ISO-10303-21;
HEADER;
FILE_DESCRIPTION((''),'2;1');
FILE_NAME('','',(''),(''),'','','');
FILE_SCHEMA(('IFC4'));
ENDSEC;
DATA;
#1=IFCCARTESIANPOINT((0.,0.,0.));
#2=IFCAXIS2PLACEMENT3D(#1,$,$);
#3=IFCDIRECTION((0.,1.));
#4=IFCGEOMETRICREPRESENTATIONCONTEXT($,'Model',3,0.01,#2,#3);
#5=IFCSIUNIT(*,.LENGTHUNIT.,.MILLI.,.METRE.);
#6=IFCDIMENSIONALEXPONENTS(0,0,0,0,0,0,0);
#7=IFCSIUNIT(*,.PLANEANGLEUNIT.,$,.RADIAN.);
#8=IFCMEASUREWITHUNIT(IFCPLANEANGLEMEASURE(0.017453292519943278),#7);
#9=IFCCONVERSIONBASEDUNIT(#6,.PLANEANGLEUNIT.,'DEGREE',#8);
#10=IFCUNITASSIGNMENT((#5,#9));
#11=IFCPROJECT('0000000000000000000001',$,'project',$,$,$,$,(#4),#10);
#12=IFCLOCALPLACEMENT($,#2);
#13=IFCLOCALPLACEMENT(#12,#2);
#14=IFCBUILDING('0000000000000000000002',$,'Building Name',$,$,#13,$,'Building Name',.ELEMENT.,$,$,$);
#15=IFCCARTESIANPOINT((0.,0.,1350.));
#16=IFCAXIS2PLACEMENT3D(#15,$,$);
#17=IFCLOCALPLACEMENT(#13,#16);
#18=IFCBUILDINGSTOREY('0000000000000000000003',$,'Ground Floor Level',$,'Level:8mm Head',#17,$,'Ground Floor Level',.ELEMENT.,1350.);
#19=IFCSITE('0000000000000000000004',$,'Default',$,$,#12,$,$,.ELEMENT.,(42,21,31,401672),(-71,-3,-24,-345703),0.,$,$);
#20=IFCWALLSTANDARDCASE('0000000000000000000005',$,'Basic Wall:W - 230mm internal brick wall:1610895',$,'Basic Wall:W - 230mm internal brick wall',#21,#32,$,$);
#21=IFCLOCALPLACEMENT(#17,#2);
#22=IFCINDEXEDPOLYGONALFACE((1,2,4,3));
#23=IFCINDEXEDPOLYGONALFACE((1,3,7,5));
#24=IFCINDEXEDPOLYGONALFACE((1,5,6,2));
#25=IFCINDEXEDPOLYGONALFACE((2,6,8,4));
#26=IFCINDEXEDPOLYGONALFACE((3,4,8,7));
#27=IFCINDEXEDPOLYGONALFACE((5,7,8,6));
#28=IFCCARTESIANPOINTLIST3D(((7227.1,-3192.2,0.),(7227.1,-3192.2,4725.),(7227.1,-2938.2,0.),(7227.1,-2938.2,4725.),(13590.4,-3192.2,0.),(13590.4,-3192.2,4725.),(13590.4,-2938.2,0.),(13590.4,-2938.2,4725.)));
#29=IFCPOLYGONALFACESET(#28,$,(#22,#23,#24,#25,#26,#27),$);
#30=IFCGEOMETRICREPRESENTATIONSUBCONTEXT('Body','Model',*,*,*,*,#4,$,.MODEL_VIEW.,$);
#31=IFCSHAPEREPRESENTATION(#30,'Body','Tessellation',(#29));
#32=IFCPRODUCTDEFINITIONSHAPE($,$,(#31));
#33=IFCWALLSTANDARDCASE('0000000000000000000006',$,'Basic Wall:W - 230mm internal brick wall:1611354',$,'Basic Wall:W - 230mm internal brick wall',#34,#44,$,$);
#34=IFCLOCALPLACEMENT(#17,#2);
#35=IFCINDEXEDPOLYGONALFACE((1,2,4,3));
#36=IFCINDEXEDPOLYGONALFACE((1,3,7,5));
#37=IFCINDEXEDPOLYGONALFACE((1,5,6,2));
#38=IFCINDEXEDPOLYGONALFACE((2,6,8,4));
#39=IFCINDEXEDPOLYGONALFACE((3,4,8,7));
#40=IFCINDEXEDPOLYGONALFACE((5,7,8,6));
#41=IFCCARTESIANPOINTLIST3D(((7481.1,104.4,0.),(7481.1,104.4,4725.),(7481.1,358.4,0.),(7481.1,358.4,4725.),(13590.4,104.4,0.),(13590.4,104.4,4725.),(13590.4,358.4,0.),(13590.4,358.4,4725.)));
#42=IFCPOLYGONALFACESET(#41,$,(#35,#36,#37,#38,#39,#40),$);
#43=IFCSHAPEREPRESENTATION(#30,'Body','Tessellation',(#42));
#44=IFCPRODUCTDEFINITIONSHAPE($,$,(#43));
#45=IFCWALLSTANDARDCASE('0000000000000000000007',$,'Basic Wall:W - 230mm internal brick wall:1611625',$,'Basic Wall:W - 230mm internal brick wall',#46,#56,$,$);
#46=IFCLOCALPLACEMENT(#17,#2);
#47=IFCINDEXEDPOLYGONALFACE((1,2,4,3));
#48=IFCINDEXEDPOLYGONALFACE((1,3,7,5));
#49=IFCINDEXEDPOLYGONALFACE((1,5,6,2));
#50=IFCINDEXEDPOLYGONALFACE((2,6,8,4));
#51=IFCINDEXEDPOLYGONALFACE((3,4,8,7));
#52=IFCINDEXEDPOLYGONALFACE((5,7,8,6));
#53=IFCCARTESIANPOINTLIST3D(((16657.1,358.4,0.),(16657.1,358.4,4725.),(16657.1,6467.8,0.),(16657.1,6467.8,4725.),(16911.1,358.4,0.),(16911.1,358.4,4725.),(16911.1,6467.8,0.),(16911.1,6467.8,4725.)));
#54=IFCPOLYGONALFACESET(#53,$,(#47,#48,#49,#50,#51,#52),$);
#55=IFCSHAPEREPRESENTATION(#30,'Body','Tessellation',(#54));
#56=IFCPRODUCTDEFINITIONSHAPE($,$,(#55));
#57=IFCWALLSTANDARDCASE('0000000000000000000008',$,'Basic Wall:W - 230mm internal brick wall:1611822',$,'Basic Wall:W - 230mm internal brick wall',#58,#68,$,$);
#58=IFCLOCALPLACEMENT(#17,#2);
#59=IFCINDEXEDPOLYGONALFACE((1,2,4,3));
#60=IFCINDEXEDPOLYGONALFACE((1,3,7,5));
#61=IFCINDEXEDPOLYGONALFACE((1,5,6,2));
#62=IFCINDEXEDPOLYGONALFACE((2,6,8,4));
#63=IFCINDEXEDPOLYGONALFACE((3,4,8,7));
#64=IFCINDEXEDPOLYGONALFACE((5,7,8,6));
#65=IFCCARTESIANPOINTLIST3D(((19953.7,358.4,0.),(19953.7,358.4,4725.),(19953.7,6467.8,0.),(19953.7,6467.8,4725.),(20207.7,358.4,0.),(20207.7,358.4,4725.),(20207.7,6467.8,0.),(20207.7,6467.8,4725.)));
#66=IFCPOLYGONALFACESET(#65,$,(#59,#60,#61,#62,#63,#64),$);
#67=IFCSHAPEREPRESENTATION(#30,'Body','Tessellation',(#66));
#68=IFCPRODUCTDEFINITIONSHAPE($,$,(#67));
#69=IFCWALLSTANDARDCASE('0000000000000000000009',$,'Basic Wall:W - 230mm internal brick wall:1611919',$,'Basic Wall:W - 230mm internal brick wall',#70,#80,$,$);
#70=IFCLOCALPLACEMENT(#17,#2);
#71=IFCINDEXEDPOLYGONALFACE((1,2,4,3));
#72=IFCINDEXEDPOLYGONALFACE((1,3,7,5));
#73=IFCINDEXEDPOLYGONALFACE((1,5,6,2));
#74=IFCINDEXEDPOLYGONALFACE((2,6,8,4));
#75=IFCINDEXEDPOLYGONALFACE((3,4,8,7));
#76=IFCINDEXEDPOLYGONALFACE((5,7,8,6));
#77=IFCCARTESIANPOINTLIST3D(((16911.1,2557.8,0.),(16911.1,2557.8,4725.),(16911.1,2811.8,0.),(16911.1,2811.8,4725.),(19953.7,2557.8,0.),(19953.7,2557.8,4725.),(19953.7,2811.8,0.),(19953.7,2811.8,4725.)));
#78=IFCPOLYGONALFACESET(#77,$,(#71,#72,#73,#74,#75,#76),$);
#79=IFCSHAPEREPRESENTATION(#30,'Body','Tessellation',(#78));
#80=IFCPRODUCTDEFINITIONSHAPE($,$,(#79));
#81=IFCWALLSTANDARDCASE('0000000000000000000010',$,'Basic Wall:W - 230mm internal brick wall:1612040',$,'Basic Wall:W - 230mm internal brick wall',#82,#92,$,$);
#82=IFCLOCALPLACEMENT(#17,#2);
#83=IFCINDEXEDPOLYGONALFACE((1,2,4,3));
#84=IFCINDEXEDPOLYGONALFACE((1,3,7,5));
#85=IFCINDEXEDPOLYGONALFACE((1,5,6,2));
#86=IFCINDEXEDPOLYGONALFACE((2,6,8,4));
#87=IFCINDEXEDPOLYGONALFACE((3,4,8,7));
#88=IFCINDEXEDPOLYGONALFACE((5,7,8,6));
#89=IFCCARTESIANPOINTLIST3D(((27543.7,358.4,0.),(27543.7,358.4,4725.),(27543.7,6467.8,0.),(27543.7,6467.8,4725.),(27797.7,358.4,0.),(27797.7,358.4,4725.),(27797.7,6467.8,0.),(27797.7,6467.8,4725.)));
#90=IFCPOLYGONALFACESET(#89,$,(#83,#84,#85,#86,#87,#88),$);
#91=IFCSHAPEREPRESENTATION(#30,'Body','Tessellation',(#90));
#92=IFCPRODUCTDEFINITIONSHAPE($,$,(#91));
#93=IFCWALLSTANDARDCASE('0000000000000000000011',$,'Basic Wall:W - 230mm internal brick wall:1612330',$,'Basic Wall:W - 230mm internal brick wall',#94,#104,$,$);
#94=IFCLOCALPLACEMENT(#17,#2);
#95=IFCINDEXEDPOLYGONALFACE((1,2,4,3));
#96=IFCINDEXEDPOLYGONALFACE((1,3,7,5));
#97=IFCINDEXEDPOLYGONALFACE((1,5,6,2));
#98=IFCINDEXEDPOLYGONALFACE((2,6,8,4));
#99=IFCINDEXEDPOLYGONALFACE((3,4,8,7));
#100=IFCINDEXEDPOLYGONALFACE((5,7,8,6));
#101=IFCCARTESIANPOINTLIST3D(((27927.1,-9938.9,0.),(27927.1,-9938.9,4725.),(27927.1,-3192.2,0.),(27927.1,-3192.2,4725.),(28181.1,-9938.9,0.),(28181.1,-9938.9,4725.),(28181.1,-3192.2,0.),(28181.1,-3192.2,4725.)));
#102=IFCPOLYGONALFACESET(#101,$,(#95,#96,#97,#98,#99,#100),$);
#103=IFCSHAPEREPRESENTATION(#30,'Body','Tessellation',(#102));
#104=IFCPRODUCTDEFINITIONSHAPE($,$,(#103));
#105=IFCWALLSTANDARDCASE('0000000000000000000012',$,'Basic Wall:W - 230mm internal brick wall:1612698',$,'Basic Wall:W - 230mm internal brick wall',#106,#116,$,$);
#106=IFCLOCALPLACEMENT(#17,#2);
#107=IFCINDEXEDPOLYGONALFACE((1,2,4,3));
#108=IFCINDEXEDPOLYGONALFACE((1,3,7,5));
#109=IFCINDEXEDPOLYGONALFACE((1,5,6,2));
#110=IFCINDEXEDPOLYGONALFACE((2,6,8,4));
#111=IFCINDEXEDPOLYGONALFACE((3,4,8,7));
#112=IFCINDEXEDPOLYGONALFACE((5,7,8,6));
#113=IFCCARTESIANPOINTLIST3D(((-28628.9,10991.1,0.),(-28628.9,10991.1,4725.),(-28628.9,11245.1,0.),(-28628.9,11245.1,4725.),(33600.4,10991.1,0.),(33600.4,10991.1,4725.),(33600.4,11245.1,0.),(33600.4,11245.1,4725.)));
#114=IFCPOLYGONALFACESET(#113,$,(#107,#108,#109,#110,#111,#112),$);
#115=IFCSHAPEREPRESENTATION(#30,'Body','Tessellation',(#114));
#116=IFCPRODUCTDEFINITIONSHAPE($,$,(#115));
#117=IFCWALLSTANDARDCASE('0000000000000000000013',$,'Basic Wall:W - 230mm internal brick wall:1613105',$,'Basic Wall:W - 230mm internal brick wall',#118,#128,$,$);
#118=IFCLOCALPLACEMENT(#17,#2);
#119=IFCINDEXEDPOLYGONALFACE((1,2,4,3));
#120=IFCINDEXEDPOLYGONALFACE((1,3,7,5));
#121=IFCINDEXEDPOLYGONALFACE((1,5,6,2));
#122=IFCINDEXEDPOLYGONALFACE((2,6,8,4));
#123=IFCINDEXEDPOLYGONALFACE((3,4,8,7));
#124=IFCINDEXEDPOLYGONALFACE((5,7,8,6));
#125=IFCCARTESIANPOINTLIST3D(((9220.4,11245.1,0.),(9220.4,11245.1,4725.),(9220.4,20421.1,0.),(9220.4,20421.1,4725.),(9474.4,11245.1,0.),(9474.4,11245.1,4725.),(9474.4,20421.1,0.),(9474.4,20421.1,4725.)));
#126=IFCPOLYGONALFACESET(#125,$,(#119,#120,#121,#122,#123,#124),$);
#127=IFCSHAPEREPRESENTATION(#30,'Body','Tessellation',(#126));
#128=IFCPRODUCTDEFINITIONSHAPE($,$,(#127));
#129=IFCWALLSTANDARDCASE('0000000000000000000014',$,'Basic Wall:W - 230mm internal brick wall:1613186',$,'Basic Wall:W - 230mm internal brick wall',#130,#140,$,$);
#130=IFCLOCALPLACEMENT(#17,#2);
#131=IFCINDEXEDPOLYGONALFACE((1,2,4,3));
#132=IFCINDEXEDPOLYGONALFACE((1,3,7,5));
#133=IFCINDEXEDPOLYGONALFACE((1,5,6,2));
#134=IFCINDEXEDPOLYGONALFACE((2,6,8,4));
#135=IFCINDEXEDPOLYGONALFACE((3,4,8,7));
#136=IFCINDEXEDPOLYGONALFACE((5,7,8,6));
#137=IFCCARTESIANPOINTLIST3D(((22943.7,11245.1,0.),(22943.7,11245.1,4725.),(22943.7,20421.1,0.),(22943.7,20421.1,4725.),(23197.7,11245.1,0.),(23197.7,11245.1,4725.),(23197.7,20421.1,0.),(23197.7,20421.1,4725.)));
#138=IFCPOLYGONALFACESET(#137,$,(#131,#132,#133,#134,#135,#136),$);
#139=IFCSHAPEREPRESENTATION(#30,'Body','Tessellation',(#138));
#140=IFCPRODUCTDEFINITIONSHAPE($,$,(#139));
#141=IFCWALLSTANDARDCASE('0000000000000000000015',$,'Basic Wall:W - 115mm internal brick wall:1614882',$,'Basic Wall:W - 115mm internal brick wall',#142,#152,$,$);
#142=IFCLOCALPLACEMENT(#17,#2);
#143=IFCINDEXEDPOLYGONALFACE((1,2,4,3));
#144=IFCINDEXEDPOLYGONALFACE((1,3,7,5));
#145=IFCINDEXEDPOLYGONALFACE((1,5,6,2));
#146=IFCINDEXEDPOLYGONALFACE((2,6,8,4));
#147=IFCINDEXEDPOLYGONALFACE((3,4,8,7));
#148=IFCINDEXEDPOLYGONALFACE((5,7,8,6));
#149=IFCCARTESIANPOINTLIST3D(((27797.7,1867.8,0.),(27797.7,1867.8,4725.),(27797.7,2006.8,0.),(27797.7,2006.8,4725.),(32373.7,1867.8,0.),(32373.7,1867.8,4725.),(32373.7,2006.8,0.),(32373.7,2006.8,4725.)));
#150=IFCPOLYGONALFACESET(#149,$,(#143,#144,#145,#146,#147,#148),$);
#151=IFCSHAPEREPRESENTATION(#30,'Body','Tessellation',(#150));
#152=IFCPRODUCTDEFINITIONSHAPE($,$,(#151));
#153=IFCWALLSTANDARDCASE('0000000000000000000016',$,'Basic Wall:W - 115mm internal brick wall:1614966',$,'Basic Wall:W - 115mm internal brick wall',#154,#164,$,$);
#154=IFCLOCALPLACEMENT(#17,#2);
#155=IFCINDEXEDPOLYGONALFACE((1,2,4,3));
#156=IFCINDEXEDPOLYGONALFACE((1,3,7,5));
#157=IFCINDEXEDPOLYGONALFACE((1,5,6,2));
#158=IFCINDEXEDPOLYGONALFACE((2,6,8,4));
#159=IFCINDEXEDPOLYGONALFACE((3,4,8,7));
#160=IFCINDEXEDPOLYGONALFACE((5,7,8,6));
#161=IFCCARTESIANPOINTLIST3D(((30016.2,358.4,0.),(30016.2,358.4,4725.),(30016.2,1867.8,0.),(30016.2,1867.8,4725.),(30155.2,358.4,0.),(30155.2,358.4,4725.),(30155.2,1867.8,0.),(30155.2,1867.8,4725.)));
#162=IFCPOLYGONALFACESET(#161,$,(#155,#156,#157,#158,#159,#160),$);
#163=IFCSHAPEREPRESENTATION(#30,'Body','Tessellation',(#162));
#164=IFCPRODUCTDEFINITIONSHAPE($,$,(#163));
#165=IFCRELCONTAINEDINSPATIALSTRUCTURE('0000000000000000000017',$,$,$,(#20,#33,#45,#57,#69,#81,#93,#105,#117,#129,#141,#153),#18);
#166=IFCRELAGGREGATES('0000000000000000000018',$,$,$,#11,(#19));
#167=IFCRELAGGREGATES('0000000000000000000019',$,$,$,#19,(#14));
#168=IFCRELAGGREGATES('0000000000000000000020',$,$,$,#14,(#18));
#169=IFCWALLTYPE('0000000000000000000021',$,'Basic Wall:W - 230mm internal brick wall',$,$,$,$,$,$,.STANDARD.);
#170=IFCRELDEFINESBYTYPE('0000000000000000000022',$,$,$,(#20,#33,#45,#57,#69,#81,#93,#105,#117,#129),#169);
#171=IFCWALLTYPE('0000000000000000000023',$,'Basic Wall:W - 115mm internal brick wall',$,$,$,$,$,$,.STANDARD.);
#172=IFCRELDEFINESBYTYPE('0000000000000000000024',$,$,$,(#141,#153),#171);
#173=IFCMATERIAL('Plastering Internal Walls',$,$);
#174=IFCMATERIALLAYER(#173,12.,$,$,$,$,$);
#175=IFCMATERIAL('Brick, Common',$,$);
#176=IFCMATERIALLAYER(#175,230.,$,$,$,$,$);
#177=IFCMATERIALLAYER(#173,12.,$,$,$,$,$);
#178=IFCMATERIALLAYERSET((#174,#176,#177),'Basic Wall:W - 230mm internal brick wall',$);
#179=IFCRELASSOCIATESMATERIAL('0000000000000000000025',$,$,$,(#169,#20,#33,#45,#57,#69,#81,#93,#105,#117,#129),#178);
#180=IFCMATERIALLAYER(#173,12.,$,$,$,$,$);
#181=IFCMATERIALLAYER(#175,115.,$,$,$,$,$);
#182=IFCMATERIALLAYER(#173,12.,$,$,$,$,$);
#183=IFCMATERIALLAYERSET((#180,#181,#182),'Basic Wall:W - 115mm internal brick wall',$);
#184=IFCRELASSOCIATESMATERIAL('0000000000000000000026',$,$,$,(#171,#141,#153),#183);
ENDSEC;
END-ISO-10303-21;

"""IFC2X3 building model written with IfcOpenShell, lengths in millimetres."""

from ifc_helpers import new_model, entity, si_unit, converted_unit, direction, frame, frame_2d, origin, place, context, subcontext, project, spatial, rectangle, extrude, material, layer, layer_set, layer_usage, type_object, element, save


model = new_model("IFC2X3")

# Units and contexts
model_context = context("Model", 3, precision=0.01, world=origin(), true_north=direction((0.0, 1.0)))
body_context = subcontext(model_context, "Body", "Model", "MODEL_VIEW")
ifc_project = project(units=[si_unit("LENGTHUNIT", "METRE", prefix="MILLI"), converted_unit("PLANEANGLEUNIT", "DEGREE", entity("IfcPlaneAngleMeasure", 0.017453292519943278), si_unit("PLANEANGLEUNIT", "RADIAN"), dimensions=[0, 0, 0, 0, 0, 0, 0])], contexts=[model_context])

# Site, building, storey
site_placement = place(None, origin())
site = spatial("IfcSite", under=ifc_project, at=site_placement, Name="Default", CompositionType="ELEMENT", RefLatitude=(42, 21, 31, 401672), RefLongitude=(-71, -3, -24, -345703), RefElevation=0.0)
building_placement = place(site_placement, origin())
building = spatial("IfcBuilding", under=site, at=building_placement, Name="Building Name", LongName="Building Name", CompositionType="ELEMENT")
storey_placement = place(building_placement, frame((0.0, 0.0, 1350.0)))
storey = spatial("IfcBuildingStorey", under=building, at=storey_placement, Name="Ground Floor Level", ObjectType="Level:8mm Head", LongName="Ground Floor Level", CompositionType="ELEMENT", Elevation=1350.0)

# Walls
ifc_material_1 = material(Name="Brick, Common")
ifc_material_2 = material(Name="Plastering Internal Walls")
ifc_layer_1 = layer(ifc_material_2, 12.0)
ifc_layer_2 = layer(ifc_material_1, 230.0)
ifc_layer_3 = layer(ifc_material_2, 12.0)
ifc_layer_set_1 = layer_set([ifc_layer_1, ifc_layer_2, ifc_layer_3], Name="Basic Wall:W - 230mm internal brick wall")
wall_type_1 = type_object("IfcWallType", Name="Basic Wall:W - 230mm internal brick wall", PredefinedType="STANDARD", material=ifc_layer_set_1)
ifc_layer_usage_1 = layer_usage(ifc_layer_set_1, "AXIS2", "NEGATIVE", 127.0)
wall_1_placement = place(storey_placement, frame((13590.4, -3065.2, 0.0), z_axis=(0.0, 0.0, 1.0), x_axis=(-1.0, 0.0, 0.0)))
element("IfcWallStandardCase", 1, at=wall_1_placement, inside=storey, type_object=wall_type_1, material=ifc_layer_usage_1, Name="Basic Wall:W - 230mm internal brick wall:1610895", ObjectType="Basic Wall:W - 230mm internal brick wall", context=body_context, shape_type="SweptSolid", body=[
    extrude(rectangle(XDim=6363.3, YDim=254.0, at=frame_2d((3181.7, 0.0), x_axis=(-1.0, 0.0))), origin(), (0.0, 0.0, 1.0), 4725.0),
])
ifc_layer_usage_2 = layer_usage(ifc_layer_set_1, "AXIS2", "NEGATIVE", 127.0)
wall_2_placement = place(storey_placement, frame((13590.4, 231.4, 0.0), z_axis=(0.0, 0.0, 1.0), x_axis=(-1.0, 0.0, 0.0)))
element("IfcWallStandardCase", 2, at=wall_2_placement, inside=storey, type_object=wall_type_1, material=ifc_layer_usage_2, Name="Basic Wall:W - 230mm internal brick wall:1611354", ObjectType="Basic Wall:W - 230mm internal brick wall", context=body_context, shape_type="SweptSolid", body=[
    extrude(rectangle(XDim=6109.3, YDim=254.0, at=frame_2d((3054.7, 0.0), x_axis=(-1.0, 0.0))), origin(), (0.0, 0.0, 1.0), 4725.0),
])
ifc_layer_usage_3 = layer_usage(ifc_layer_set_1, "AXIS2", "NEGATIVE", 127.0)
wall_3_placement = place(storey_placement, frame((16784.1, 358.4, 0.0), z_axis=(0.0, 0.0, 1.0), x_axis=(0.0, 1.0, 0.0)))
element("IfcWallStandardCase", 3, at=wall_3_placement, inside=storey, type_object=wall_type_1, material=ifc_layer_usage_3, Name="Basic Wall:W - 230mm internal brick wall:1611625", ObjectType="Basic Wall:W - 230mm internal brick wall", context=body_context, shape_type="SweptSolid", body=[
    extrude(rectangle(XDim=6109.3, YDim=254.0, at=frame_2d((3054.7, 0.0), x_axis=(-1.0, 0.0))), origin(), (0.0, 0.0, 1.0), 4725.0),
])
ifc_layer_usage_4 = layer_usage(ifc_layer_set_1, "AXIS2", "NEGATIVE", 127.0)
wall_4_placement = place(storey_placement, frame((20080.7, 358.4, 0.0), z_axis=(0.0, 0.0, 1.0), x_axis=(0.0, 1.0, 0.0)))
element("IfcWallStandardCase", 4, at=wall_4_placement, inside=storey, type_object=wall_type_1, material=ifc_layer_usage_4, Name="Basic Wall:W - 230mm internal brick wall:1611822", ObjectType="Basic Wall:W - 230mm internal brick wall", context=body_context, shape_type="SweptSolid", body=[
    extrude(rectangle(XDim=6109.3, YDim=254.0, at=frame_2d((3054.7, 0.0), x_axis=(-1.0, 0.0))), origin(), (0.0, 0.0, 1.0), 4725.0),
])
ifc_layer_usage_5 = layer_usage(ifc_layer_set_1, "AXIS2", "NEGATIVE", 127.0)
wall_5_placement = place(storey_placement, frame((19953.7, 2684.8, 0.0), z_axis=(0.0, 0.0, 1.0), x_axis=(-1.0, 0.0, 0.0)))
element("IfcWallStandardCase", 5, at=wall_5_placement, inside=storey, type_object=wall_type_1, material=ifc_layer_usage_5, Name="Basic Wall:W - 230mm internal brick wall:1611919", ObjectType="Basic Wall:W - 230mm internal brick wall", context=body_context, shape_type="SweptSolid", body=[
    extrude(rectangle(XDim=3042.7, YDim=254.0, at=frame_2d((1521.3, 0.0), x_axis=(-1.0, 0.0))), origin(), (0.0, 0.0, 1.0), 4725.0),
])
ifc_layer_usage_6 = layer_usage(ifc_layer_set_1, "AXIS2", "NEGATIVE", 127.0)
wall_6_placement = place(storey_placement, frame((27670.7, 358.4, 0.0), z_axis=(0.0, 0.0, 1.0), x_axis=(0.0, 1.0, 0.0)))
element("IfcWallStandardCase", 6, at=wall_6_placement, inside=storey, type_object=wall_type_1, material=ifc_layer_usage_6, Name="Basic Wall:W - 230mm internal brick wall:1612040", ObjectType="Basic Wall:W - 230mm internal brick wall", context=body_context, shape_type="SweptSolid", body=[
    extrude(rectangle(XDim=6109.3, YDim=254.0, at=frame_2d((3054.7, 0.0), x_axis=(-1.0, 0.0))), origin(), (0.0, 0.0, 1.0), 4725.0),
])
ifc_layer_usage_7 = layer_usage(ifc_layer_set_1, "AXIS2", "NEGATIVE", 127.0)
wall_7_placement = place(storey_placement, frame((28054.1, -3192.2, 0.0), z_axis=(0.0, 0.0, 1.0), x_axis=(0.0, -1.0, 0.0)))
element("IfcWallStandardCase", 7, at=wall_7_placement, inside=storey, type_object=wall_type_1, material=ifc_layer_usage_7, Name="Basic Wall:W - 230mm internal brick wall:1612330", ObjectType="Basic Wall:W - 230mm internal brick wall", context=body_context, shape_type="SweptSolid", body=[
    extrude(rectangle(XDim=6746.7, YDim=254.0, at=frame_2d((3373.3, 0.0), x_axis=(-1.0, 0.0))), origin(), (0.0, 0.0, 1.0), 4725.0),
])
ifc_layer_usage_8 = layer_usage(ifc_layer_set_1, "AXIS2", "NEGATIVE", 127.0)
wall_8_placement = place(storey_placement, frame((33600.4, 11118.1, 0.0), z_axis=(0.0, 0.0, 1.0), x_axis=(-1.0, 0.0, 0.0)))
element("IfcWallStandardCase", 8, at=wall_8_placement, inside=storey, type_object=wall_type_1, material=ifc_layer_usage_8, Name="Basic Wall:W - 230mm internal brick wall:1612698", ObjectType="Basic Wall:W - 230mm internal brick wall", context=body_context, shape_type="SweptSolid", body=[
    extrude(rectangle(XDim=62229.3, YDim=254.0, at=frame_2d((31114.7, 0.0), x_axis=(-1.0, 0.0))), origin(), (0.0, 0.0, 1.0), 4725.0),
])
ifc_layer_usage_9 = layer_usage(ifc_layer_set_1, "AXIS2", "NEGATIVE", 127.0)
wall_9_placement = place(storey_placement, frame((9347.4, 11245.1, 0.0), z_axis=(0.0, 0.0, 1.0), x_axis=(0.0, 1.0, 0.0)))
element("IfcWallStandardCase", 9, at=wall_9_placement, inside=storey, type_object=wall_type_1, material=ifc_layer_usage_9, Name="Basic Wall:W - 230mm internal brick wall:1613105", ObjectType="Basic Wall:W - 230mm internal brick wall", context=body_context, shape_type="SweptSolid", body=[
    extrude(rectangle(XDim=9176.0, YDim=254.0, at=frame_2d((4588.0, 0.0), x_axis=(-1.0, 0.0))), origin(), (0.0, 0.0, 1.0), 4725.0),
])
ifc_layer_usage_10 = layer_usage(ifc_layer_set_1, "AXIS2", "NEGATIVE", 127.0)
wall_10_placement = place(storey_placement, frame((23070.7, 11245.1, 0.0), z_axis=(0.0, 0.0, 1.0), x_axis=(0.0, 1.0, 0.0)))
element("IfcWallStandardCase", 10, at=wall_10_placement, inside=storey, type_object=wall_type_1, material=ifc_layer_usage_10, Name="Basic Wall:W - 230mm internal brick wall:1613186", ObjectType="Basic Wall:W - 230mm internal brick wall", context=body_context, shape_type="SweptSolid", body=[
    extrude(rectangle(XDim=9176.0, YDim=254.0, at=frame_2d((4588.0, 0.0), x_axis=(-1.0, 0.0))), origin(), (0.0, 0.0, 1.0), 4725.0),
])
ifc_layer_4 = layer(ifc_material_2, 12.0)
ifc_layer_5 = layer(ifc_material_1, 115.0)
ifc_layer_6 = layer(ifc_material_2, 12.0)
ifc_layer_set_2 = layer_set([ifc_layer_4, ifc_layer_5, ifc_layer_6], Name="Basic Wall:W - 115mm internal brick wall")
ifc_layer_usage_11 = layer_usage(ifc_layer_set_2, "AXIS2", "NEGATIVE", 69.5)
wall_type_2 = type_object("IfcWallType", Name="Basic Wall:W - 115mm internal brick wall", PredefinedType="STANDARD", material=ifc_layer_set_2)
wall_11_placement = place(storey_placement, frame((32373.7, 1937.3, 0.0), z_axis=(0.0, 0.0, 1.0), x_axis=(-1.0, 0.0, 0.0)))
element("IfcWallStandardCase", 11, at=wall_11_placement, inside=storey, type_object=wall_type_2, material=ifc_layer_usage_11, Name="Basic Wall:W - 115mm internal brick wall:1614882", ObjectType="Basic Wall:W - 115mm internal brick wall", context=body_context, shape_type="SweptSolid", body=[
    extrude(rectangle(XDim=4576.0, YDim=139.0, at=frame_2d((2288.0, 0.0), x_axis=(-1.0, 0.0))), origin(), (0.0, 0.0, 1.0), 4725.0),
])
ifc_layer_usage_12 = layer_usage(ifc_layer_set_2, "AXIS2", "NEGATIVE", 69.5)
wall_12_placement = place(storey_placement, frame((30085.7, 358.4, 0.0), z_axis=(0.0, 0.0, 1.0), x_axis=(0.0, 1.0, 0.0)))
element("IfcWallStandardCase", 12, at=wall_12_placement, inside=storey, type_object=wall_type_2, material=ifc_layer_usage_12, Name="Basic Wall:W - 115mm internal brick wall:1614966", ObjectType="Basic Wall:W - 115mm internal brick wall", context=body_context, shape_type="SweptSolid", body=[
    extrude(rectangle(XDim=1509.3, YDim=139.0, at=frame_2d((754.7, 0.0), x_axis=(-1.0, 0.0))), origin(), (0.0, 0.0, 1.0), 4725.0),
])

save(model, "model.ifc")
